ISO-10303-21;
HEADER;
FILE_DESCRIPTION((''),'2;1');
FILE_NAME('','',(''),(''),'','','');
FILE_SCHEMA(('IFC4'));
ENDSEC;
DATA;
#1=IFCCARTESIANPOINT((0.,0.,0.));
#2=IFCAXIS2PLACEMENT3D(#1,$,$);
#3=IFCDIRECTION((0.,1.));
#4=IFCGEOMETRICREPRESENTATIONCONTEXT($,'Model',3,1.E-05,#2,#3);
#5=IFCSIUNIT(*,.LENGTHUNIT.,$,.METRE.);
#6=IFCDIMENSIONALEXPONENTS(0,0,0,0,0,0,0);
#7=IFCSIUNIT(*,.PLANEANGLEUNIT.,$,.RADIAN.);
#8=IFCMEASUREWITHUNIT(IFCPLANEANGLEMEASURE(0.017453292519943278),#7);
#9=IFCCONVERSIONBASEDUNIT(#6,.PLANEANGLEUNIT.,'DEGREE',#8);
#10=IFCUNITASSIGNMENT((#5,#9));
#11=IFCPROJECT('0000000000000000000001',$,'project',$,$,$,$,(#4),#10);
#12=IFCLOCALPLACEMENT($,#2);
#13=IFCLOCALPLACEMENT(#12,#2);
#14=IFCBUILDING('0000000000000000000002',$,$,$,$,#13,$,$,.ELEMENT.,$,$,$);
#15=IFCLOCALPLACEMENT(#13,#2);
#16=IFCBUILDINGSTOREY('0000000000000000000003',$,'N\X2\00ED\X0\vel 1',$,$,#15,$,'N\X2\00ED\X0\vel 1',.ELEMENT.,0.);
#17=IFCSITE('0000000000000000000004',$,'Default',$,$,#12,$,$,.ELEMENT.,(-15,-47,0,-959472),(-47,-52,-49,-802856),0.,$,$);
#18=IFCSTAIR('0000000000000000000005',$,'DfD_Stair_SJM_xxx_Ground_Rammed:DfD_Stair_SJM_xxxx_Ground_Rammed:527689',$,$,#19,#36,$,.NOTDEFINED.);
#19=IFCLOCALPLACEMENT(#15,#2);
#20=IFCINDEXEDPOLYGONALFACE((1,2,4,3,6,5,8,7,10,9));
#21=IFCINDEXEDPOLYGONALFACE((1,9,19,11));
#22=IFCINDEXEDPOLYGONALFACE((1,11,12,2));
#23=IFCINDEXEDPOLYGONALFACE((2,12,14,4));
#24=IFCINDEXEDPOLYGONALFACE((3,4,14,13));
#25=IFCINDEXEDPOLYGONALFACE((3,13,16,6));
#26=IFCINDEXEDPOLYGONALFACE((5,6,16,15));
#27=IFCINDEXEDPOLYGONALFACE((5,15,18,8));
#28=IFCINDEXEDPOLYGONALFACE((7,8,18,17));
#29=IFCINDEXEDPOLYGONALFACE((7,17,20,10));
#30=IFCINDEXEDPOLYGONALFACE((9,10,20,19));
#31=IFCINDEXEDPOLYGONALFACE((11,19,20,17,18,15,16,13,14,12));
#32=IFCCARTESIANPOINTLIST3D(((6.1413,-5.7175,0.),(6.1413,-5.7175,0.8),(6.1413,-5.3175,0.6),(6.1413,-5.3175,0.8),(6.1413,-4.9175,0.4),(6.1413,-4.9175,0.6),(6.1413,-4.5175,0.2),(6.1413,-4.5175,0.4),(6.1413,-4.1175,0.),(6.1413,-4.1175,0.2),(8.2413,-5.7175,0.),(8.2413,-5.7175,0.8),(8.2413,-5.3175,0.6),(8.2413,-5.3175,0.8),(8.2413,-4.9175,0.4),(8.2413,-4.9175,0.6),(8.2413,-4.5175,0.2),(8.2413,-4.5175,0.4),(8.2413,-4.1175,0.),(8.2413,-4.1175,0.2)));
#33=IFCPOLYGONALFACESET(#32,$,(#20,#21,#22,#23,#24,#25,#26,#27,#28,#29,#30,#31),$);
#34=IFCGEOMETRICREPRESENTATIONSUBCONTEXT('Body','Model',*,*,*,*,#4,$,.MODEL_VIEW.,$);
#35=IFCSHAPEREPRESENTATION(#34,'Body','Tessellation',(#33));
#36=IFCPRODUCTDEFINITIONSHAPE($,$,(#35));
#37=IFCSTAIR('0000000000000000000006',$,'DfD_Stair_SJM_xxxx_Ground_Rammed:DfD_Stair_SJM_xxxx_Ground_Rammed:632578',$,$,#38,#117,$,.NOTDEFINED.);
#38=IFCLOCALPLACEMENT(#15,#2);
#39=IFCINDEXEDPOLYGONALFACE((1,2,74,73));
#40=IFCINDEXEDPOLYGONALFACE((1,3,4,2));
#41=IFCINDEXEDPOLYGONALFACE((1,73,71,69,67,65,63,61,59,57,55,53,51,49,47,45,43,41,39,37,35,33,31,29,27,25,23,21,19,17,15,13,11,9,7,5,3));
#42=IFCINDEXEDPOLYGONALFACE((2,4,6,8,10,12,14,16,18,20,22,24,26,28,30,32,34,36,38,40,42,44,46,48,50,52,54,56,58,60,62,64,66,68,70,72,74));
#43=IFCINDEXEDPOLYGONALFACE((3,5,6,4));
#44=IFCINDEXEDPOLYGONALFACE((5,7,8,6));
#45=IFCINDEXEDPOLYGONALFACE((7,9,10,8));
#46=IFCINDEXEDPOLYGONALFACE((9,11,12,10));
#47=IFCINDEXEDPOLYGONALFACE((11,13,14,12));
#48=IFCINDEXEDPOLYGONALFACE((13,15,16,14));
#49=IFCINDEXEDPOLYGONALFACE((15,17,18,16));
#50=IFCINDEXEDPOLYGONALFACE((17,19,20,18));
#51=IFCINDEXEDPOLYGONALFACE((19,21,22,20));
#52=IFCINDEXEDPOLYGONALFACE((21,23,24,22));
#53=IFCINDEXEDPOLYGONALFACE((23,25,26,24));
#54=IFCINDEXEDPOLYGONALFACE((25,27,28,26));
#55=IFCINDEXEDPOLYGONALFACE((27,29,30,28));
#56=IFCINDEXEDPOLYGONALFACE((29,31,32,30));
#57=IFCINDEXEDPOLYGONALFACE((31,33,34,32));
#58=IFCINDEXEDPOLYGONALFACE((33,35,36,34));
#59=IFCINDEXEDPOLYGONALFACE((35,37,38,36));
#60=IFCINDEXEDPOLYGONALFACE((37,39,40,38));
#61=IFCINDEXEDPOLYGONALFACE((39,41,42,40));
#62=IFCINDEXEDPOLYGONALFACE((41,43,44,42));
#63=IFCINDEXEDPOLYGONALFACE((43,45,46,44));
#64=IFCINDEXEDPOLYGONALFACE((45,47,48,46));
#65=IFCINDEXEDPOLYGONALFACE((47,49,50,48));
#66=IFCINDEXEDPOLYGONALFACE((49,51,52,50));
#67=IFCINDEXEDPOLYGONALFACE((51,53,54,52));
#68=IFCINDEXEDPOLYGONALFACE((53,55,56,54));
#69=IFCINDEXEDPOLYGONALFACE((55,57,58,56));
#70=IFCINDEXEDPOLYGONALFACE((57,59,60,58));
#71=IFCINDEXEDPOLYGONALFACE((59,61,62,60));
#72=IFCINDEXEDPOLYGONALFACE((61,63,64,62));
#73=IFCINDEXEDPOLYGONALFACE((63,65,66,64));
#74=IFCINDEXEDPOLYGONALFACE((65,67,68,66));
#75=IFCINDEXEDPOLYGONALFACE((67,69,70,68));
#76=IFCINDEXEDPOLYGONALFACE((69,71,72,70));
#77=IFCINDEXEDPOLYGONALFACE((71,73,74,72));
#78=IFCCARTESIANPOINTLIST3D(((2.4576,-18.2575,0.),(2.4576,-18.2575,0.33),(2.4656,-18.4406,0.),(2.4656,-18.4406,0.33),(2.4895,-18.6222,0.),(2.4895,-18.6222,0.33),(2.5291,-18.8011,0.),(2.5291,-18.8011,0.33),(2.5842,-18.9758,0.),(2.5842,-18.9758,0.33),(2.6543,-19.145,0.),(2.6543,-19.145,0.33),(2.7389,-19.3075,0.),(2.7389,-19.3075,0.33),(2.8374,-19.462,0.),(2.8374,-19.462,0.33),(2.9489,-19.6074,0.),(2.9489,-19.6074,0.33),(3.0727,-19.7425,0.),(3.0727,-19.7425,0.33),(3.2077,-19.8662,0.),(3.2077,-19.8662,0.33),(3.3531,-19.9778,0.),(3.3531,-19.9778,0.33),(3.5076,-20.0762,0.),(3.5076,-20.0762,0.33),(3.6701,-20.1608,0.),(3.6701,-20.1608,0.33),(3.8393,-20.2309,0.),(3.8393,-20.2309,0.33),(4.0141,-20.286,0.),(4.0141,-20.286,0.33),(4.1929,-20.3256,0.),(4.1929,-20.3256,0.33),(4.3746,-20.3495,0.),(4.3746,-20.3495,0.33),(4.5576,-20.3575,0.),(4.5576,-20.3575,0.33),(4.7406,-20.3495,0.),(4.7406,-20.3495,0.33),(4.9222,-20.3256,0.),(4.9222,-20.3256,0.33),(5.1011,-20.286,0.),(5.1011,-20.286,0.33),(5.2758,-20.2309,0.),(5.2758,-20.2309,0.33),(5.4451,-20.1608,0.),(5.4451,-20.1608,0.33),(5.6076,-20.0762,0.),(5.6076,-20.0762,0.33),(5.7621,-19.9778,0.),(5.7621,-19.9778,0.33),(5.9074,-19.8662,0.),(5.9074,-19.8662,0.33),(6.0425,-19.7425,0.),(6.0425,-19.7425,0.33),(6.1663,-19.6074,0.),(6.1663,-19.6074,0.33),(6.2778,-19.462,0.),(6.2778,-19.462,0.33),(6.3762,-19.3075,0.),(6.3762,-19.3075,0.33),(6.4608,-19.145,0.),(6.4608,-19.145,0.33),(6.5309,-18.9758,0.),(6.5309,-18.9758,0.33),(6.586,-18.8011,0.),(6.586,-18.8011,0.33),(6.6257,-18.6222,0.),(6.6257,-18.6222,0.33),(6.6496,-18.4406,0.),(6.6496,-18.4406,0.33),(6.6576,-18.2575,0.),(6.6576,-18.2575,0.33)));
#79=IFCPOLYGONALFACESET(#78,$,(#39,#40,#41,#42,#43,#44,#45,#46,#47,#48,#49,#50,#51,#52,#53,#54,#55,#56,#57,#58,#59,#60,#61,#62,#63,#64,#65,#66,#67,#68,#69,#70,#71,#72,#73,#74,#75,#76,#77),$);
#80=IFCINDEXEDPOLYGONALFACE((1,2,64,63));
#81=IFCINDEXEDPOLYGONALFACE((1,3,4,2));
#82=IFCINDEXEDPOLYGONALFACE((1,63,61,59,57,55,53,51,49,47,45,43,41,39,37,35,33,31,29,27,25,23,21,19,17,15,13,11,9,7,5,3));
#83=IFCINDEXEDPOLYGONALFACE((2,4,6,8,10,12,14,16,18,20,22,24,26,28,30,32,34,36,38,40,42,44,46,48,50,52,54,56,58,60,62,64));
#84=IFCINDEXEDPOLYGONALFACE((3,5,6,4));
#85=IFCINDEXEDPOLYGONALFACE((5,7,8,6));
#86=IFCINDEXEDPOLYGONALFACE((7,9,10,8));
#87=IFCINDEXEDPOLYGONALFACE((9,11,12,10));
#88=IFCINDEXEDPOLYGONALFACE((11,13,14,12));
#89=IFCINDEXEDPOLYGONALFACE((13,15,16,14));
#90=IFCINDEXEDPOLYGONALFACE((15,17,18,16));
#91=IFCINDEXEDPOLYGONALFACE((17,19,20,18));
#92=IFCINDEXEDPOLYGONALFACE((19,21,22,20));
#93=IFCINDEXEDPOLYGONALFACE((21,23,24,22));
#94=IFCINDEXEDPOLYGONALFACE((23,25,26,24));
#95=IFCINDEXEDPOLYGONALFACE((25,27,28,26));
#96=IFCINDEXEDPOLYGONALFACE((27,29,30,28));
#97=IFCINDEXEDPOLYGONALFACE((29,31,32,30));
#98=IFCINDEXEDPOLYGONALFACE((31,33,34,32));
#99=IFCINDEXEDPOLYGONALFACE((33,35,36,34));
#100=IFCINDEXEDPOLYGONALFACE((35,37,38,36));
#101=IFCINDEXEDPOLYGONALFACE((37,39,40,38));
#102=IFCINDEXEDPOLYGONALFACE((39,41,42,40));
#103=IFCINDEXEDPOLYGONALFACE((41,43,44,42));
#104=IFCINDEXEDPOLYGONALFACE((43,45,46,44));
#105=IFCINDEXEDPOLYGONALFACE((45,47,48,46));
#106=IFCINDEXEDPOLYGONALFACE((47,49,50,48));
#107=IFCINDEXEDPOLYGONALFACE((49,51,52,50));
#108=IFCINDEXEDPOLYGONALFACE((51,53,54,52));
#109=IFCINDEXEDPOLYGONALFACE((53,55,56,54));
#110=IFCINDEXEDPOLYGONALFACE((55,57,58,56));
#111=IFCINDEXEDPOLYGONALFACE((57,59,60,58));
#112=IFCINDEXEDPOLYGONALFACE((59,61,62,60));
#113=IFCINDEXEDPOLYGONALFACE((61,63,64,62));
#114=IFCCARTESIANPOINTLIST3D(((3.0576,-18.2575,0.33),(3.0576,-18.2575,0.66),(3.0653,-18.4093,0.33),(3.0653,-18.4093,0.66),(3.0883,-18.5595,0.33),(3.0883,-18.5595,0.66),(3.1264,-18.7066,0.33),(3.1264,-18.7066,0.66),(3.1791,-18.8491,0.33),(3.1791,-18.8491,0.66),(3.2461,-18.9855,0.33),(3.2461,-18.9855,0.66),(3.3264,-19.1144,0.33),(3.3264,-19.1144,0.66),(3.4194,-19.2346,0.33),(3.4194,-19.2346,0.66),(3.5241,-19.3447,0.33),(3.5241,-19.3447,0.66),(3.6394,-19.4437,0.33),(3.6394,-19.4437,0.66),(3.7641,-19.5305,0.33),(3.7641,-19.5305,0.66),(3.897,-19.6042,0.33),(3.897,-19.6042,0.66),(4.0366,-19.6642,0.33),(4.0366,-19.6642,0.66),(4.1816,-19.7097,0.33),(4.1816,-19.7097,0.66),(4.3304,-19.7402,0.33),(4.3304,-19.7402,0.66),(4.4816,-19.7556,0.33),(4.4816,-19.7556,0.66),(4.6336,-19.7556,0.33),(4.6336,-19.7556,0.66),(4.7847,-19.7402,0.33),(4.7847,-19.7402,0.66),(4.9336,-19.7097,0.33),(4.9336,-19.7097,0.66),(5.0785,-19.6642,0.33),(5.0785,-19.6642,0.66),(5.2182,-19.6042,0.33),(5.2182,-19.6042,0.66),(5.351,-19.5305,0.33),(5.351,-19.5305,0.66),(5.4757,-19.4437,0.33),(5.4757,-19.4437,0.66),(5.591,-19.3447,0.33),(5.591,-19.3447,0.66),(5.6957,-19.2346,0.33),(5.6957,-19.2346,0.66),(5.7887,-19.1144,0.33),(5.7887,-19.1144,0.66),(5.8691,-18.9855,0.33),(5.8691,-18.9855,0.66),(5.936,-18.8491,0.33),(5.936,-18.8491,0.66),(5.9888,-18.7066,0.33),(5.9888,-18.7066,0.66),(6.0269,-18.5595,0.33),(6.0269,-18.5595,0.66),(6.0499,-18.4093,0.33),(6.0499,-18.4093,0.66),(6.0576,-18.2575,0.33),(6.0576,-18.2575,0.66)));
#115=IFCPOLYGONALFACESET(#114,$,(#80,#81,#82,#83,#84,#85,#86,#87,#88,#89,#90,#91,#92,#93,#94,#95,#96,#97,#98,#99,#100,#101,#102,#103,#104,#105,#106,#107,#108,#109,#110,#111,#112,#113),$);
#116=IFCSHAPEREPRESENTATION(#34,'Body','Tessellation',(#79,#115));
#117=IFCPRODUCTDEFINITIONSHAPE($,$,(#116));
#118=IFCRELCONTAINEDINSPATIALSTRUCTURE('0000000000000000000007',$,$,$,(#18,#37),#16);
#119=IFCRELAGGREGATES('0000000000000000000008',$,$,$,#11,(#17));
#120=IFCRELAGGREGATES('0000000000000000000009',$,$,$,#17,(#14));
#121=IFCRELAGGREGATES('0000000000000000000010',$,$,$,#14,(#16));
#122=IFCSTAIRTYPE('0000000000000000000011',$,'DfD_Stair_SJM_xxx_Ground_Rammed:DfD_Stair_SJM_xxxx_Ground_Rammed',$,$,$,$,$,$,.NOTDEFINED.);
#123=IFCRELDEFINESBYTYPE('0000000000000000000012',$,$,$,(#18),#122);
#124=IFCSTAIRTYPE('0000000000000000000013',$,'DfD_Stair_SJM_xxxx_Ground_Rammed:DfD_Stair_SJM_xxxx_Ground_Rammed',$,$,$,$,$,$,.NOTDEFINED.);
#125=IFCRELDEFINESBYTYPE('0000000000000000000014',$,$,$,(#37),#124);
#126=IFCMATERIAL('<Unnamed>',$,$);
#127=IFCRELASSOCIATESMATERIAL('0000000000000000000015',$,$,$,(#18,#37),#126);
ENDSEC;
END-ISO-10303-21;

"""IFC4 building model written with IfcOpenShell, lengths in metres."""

from ifc_helpers import new_model, entity, si_unit, converted_unit, direction, frame, origin, place, context, subcontext, project, spatial, line, arc, indexed_curve, outline, extrude, material, type_object, element, save


model = new_model("IFC4")

# Units and contexts
model_context = context("Model", 3, precision=1e-05, world=origin(), true_north=direction((0.0, 1.0)))
body_context = subcontext(model_context, "Body", "Model", "MODEL_VIEW")
ifc_project = project(units=[si_unit("LENGTHUNIT", "METRE"), converted_unit("PLANEANGLEUNIT", "DEGREE", entity("IfcPlaneAngleMeasure", 0.017453292519943278), si_unit("PLANEANGLEUNIT", "RADIAN"), dimensions=[0, 0, 0, 0, 0, 0, 0])], contexts=[model_context])

# Site, building, storey
site_placement = place(None, origin())
site = spatial("IfcSite", under=ifc_project, at=site_placement, Name="Default", CompositionType="ELEMENT", RefLatitude=(-15, -47, 0, -959472), RefLongitude=(-47, -52, -49, -802856), RefElevation=0.0)
building_placement = place(site_placement, origin())
building = spatial("IfcBuilding", under=site, at=building_placement, CompositionType="ELEMENT")
storey_placement = place(building_placement, origin())
storey = spatial("IfcBuildingStorey", under=building, at=storey_placement, Name="Nível 1", LongName="Nível 1", CompositionType="ELEMENT", Elevation=0.0)

# Stairs
ifc_material_1 = material(Name="<Unnamed>")
stair_type_1 = type_object("IfcStairType", Name="DfD_Stair_SJM_xxx_Ground_Rammed:DfD_Stair_SJM_xxxx_Ground_Rammed", PredefinedType="NOTDEFINED")
stair_1_placement = place(storey_placement, origin())
element("IfcStair", 1, at=stair_1_placement, inside=storey, type_object=stair_type_1, material=ifc_material_1, Name="DfD_Stair_SJM_xxx_Ground_Rammed:DfD_Stair_SJM_xxxx_Ground_Rammed:527689", PredefinedType="NOTDEFINED", context=body_context, shape_type="SweptSolid", body=[
    extrude(outline(indexed_curve([(-0.8, -0.4), (0.8, -0.4), (0.8, -0.2), (0.4, -0.2), (0.4, 0.0), (0.0, 0.0), (0.0, 0.2), (-0.4, 0.2), (-0.4, 0.4), (-0.8, 0.4), (-0.8, -0.4)], self_intersect=False)), frame((6.1413, -4.9175, 0.4), z_axis=(1.0, 0.0, 0.0), x_axis=(0.0, 1.0, 0.0)), (0.0, 0.0, 1.0), 2.1),
])
stair_type_2 = type_object("IfcStairType", Name="DfD_Stair_SJM_xxxx_Ground_Rammed:DfD_Stair_SJM_xxxx_Ground_Rammed", PredefinedType="NOTDEFINED")
stair_2_placement = place(storey_placement, origin())
element("IfcStair", 2, at=stair_2_placement, inside=storey, type_object=stair_type_2, material=ifc_material_1, Name="DfD_Stair_SJM_xxxx_Ground_Rammed:DfD_Stair_SJM_xxxx_Ground_Rammed:632578", PredefinedType="NOTDEFINED", context=body_context, shape_type="SweptSolid", body=[
    extrude(outline(indexed_curve([(-2.1, 0.0), (0.0, -2.1), (2.1, 0.0)], segments=[arc(1, 2, 3), line(3, 1)], self_intersect=False)), frame((4.5576, -18.2575, 0.0), z_axis=(0.0, 0.0, -1.0), x_axis=(-1.0, 0.0, 0.0)), (0.0, 0.0, -1.0), 0.33),
    extrude(outline(indexed_curve([(-1.5, 0.0), (0.0, -1.5), (1.5, 0.0)], segments=[arc(1, 2, 3), line(3, 1)], self_intersect=False)), frame((4.5576, -18.2575, 0.33), z_axis=(0.0, 0.0, -1.0), x_axis=(-1.0, 0.0, 0.0)), (0.0, 0.0, -1.0), 0.33),
])

save(model, "model.ifc")
